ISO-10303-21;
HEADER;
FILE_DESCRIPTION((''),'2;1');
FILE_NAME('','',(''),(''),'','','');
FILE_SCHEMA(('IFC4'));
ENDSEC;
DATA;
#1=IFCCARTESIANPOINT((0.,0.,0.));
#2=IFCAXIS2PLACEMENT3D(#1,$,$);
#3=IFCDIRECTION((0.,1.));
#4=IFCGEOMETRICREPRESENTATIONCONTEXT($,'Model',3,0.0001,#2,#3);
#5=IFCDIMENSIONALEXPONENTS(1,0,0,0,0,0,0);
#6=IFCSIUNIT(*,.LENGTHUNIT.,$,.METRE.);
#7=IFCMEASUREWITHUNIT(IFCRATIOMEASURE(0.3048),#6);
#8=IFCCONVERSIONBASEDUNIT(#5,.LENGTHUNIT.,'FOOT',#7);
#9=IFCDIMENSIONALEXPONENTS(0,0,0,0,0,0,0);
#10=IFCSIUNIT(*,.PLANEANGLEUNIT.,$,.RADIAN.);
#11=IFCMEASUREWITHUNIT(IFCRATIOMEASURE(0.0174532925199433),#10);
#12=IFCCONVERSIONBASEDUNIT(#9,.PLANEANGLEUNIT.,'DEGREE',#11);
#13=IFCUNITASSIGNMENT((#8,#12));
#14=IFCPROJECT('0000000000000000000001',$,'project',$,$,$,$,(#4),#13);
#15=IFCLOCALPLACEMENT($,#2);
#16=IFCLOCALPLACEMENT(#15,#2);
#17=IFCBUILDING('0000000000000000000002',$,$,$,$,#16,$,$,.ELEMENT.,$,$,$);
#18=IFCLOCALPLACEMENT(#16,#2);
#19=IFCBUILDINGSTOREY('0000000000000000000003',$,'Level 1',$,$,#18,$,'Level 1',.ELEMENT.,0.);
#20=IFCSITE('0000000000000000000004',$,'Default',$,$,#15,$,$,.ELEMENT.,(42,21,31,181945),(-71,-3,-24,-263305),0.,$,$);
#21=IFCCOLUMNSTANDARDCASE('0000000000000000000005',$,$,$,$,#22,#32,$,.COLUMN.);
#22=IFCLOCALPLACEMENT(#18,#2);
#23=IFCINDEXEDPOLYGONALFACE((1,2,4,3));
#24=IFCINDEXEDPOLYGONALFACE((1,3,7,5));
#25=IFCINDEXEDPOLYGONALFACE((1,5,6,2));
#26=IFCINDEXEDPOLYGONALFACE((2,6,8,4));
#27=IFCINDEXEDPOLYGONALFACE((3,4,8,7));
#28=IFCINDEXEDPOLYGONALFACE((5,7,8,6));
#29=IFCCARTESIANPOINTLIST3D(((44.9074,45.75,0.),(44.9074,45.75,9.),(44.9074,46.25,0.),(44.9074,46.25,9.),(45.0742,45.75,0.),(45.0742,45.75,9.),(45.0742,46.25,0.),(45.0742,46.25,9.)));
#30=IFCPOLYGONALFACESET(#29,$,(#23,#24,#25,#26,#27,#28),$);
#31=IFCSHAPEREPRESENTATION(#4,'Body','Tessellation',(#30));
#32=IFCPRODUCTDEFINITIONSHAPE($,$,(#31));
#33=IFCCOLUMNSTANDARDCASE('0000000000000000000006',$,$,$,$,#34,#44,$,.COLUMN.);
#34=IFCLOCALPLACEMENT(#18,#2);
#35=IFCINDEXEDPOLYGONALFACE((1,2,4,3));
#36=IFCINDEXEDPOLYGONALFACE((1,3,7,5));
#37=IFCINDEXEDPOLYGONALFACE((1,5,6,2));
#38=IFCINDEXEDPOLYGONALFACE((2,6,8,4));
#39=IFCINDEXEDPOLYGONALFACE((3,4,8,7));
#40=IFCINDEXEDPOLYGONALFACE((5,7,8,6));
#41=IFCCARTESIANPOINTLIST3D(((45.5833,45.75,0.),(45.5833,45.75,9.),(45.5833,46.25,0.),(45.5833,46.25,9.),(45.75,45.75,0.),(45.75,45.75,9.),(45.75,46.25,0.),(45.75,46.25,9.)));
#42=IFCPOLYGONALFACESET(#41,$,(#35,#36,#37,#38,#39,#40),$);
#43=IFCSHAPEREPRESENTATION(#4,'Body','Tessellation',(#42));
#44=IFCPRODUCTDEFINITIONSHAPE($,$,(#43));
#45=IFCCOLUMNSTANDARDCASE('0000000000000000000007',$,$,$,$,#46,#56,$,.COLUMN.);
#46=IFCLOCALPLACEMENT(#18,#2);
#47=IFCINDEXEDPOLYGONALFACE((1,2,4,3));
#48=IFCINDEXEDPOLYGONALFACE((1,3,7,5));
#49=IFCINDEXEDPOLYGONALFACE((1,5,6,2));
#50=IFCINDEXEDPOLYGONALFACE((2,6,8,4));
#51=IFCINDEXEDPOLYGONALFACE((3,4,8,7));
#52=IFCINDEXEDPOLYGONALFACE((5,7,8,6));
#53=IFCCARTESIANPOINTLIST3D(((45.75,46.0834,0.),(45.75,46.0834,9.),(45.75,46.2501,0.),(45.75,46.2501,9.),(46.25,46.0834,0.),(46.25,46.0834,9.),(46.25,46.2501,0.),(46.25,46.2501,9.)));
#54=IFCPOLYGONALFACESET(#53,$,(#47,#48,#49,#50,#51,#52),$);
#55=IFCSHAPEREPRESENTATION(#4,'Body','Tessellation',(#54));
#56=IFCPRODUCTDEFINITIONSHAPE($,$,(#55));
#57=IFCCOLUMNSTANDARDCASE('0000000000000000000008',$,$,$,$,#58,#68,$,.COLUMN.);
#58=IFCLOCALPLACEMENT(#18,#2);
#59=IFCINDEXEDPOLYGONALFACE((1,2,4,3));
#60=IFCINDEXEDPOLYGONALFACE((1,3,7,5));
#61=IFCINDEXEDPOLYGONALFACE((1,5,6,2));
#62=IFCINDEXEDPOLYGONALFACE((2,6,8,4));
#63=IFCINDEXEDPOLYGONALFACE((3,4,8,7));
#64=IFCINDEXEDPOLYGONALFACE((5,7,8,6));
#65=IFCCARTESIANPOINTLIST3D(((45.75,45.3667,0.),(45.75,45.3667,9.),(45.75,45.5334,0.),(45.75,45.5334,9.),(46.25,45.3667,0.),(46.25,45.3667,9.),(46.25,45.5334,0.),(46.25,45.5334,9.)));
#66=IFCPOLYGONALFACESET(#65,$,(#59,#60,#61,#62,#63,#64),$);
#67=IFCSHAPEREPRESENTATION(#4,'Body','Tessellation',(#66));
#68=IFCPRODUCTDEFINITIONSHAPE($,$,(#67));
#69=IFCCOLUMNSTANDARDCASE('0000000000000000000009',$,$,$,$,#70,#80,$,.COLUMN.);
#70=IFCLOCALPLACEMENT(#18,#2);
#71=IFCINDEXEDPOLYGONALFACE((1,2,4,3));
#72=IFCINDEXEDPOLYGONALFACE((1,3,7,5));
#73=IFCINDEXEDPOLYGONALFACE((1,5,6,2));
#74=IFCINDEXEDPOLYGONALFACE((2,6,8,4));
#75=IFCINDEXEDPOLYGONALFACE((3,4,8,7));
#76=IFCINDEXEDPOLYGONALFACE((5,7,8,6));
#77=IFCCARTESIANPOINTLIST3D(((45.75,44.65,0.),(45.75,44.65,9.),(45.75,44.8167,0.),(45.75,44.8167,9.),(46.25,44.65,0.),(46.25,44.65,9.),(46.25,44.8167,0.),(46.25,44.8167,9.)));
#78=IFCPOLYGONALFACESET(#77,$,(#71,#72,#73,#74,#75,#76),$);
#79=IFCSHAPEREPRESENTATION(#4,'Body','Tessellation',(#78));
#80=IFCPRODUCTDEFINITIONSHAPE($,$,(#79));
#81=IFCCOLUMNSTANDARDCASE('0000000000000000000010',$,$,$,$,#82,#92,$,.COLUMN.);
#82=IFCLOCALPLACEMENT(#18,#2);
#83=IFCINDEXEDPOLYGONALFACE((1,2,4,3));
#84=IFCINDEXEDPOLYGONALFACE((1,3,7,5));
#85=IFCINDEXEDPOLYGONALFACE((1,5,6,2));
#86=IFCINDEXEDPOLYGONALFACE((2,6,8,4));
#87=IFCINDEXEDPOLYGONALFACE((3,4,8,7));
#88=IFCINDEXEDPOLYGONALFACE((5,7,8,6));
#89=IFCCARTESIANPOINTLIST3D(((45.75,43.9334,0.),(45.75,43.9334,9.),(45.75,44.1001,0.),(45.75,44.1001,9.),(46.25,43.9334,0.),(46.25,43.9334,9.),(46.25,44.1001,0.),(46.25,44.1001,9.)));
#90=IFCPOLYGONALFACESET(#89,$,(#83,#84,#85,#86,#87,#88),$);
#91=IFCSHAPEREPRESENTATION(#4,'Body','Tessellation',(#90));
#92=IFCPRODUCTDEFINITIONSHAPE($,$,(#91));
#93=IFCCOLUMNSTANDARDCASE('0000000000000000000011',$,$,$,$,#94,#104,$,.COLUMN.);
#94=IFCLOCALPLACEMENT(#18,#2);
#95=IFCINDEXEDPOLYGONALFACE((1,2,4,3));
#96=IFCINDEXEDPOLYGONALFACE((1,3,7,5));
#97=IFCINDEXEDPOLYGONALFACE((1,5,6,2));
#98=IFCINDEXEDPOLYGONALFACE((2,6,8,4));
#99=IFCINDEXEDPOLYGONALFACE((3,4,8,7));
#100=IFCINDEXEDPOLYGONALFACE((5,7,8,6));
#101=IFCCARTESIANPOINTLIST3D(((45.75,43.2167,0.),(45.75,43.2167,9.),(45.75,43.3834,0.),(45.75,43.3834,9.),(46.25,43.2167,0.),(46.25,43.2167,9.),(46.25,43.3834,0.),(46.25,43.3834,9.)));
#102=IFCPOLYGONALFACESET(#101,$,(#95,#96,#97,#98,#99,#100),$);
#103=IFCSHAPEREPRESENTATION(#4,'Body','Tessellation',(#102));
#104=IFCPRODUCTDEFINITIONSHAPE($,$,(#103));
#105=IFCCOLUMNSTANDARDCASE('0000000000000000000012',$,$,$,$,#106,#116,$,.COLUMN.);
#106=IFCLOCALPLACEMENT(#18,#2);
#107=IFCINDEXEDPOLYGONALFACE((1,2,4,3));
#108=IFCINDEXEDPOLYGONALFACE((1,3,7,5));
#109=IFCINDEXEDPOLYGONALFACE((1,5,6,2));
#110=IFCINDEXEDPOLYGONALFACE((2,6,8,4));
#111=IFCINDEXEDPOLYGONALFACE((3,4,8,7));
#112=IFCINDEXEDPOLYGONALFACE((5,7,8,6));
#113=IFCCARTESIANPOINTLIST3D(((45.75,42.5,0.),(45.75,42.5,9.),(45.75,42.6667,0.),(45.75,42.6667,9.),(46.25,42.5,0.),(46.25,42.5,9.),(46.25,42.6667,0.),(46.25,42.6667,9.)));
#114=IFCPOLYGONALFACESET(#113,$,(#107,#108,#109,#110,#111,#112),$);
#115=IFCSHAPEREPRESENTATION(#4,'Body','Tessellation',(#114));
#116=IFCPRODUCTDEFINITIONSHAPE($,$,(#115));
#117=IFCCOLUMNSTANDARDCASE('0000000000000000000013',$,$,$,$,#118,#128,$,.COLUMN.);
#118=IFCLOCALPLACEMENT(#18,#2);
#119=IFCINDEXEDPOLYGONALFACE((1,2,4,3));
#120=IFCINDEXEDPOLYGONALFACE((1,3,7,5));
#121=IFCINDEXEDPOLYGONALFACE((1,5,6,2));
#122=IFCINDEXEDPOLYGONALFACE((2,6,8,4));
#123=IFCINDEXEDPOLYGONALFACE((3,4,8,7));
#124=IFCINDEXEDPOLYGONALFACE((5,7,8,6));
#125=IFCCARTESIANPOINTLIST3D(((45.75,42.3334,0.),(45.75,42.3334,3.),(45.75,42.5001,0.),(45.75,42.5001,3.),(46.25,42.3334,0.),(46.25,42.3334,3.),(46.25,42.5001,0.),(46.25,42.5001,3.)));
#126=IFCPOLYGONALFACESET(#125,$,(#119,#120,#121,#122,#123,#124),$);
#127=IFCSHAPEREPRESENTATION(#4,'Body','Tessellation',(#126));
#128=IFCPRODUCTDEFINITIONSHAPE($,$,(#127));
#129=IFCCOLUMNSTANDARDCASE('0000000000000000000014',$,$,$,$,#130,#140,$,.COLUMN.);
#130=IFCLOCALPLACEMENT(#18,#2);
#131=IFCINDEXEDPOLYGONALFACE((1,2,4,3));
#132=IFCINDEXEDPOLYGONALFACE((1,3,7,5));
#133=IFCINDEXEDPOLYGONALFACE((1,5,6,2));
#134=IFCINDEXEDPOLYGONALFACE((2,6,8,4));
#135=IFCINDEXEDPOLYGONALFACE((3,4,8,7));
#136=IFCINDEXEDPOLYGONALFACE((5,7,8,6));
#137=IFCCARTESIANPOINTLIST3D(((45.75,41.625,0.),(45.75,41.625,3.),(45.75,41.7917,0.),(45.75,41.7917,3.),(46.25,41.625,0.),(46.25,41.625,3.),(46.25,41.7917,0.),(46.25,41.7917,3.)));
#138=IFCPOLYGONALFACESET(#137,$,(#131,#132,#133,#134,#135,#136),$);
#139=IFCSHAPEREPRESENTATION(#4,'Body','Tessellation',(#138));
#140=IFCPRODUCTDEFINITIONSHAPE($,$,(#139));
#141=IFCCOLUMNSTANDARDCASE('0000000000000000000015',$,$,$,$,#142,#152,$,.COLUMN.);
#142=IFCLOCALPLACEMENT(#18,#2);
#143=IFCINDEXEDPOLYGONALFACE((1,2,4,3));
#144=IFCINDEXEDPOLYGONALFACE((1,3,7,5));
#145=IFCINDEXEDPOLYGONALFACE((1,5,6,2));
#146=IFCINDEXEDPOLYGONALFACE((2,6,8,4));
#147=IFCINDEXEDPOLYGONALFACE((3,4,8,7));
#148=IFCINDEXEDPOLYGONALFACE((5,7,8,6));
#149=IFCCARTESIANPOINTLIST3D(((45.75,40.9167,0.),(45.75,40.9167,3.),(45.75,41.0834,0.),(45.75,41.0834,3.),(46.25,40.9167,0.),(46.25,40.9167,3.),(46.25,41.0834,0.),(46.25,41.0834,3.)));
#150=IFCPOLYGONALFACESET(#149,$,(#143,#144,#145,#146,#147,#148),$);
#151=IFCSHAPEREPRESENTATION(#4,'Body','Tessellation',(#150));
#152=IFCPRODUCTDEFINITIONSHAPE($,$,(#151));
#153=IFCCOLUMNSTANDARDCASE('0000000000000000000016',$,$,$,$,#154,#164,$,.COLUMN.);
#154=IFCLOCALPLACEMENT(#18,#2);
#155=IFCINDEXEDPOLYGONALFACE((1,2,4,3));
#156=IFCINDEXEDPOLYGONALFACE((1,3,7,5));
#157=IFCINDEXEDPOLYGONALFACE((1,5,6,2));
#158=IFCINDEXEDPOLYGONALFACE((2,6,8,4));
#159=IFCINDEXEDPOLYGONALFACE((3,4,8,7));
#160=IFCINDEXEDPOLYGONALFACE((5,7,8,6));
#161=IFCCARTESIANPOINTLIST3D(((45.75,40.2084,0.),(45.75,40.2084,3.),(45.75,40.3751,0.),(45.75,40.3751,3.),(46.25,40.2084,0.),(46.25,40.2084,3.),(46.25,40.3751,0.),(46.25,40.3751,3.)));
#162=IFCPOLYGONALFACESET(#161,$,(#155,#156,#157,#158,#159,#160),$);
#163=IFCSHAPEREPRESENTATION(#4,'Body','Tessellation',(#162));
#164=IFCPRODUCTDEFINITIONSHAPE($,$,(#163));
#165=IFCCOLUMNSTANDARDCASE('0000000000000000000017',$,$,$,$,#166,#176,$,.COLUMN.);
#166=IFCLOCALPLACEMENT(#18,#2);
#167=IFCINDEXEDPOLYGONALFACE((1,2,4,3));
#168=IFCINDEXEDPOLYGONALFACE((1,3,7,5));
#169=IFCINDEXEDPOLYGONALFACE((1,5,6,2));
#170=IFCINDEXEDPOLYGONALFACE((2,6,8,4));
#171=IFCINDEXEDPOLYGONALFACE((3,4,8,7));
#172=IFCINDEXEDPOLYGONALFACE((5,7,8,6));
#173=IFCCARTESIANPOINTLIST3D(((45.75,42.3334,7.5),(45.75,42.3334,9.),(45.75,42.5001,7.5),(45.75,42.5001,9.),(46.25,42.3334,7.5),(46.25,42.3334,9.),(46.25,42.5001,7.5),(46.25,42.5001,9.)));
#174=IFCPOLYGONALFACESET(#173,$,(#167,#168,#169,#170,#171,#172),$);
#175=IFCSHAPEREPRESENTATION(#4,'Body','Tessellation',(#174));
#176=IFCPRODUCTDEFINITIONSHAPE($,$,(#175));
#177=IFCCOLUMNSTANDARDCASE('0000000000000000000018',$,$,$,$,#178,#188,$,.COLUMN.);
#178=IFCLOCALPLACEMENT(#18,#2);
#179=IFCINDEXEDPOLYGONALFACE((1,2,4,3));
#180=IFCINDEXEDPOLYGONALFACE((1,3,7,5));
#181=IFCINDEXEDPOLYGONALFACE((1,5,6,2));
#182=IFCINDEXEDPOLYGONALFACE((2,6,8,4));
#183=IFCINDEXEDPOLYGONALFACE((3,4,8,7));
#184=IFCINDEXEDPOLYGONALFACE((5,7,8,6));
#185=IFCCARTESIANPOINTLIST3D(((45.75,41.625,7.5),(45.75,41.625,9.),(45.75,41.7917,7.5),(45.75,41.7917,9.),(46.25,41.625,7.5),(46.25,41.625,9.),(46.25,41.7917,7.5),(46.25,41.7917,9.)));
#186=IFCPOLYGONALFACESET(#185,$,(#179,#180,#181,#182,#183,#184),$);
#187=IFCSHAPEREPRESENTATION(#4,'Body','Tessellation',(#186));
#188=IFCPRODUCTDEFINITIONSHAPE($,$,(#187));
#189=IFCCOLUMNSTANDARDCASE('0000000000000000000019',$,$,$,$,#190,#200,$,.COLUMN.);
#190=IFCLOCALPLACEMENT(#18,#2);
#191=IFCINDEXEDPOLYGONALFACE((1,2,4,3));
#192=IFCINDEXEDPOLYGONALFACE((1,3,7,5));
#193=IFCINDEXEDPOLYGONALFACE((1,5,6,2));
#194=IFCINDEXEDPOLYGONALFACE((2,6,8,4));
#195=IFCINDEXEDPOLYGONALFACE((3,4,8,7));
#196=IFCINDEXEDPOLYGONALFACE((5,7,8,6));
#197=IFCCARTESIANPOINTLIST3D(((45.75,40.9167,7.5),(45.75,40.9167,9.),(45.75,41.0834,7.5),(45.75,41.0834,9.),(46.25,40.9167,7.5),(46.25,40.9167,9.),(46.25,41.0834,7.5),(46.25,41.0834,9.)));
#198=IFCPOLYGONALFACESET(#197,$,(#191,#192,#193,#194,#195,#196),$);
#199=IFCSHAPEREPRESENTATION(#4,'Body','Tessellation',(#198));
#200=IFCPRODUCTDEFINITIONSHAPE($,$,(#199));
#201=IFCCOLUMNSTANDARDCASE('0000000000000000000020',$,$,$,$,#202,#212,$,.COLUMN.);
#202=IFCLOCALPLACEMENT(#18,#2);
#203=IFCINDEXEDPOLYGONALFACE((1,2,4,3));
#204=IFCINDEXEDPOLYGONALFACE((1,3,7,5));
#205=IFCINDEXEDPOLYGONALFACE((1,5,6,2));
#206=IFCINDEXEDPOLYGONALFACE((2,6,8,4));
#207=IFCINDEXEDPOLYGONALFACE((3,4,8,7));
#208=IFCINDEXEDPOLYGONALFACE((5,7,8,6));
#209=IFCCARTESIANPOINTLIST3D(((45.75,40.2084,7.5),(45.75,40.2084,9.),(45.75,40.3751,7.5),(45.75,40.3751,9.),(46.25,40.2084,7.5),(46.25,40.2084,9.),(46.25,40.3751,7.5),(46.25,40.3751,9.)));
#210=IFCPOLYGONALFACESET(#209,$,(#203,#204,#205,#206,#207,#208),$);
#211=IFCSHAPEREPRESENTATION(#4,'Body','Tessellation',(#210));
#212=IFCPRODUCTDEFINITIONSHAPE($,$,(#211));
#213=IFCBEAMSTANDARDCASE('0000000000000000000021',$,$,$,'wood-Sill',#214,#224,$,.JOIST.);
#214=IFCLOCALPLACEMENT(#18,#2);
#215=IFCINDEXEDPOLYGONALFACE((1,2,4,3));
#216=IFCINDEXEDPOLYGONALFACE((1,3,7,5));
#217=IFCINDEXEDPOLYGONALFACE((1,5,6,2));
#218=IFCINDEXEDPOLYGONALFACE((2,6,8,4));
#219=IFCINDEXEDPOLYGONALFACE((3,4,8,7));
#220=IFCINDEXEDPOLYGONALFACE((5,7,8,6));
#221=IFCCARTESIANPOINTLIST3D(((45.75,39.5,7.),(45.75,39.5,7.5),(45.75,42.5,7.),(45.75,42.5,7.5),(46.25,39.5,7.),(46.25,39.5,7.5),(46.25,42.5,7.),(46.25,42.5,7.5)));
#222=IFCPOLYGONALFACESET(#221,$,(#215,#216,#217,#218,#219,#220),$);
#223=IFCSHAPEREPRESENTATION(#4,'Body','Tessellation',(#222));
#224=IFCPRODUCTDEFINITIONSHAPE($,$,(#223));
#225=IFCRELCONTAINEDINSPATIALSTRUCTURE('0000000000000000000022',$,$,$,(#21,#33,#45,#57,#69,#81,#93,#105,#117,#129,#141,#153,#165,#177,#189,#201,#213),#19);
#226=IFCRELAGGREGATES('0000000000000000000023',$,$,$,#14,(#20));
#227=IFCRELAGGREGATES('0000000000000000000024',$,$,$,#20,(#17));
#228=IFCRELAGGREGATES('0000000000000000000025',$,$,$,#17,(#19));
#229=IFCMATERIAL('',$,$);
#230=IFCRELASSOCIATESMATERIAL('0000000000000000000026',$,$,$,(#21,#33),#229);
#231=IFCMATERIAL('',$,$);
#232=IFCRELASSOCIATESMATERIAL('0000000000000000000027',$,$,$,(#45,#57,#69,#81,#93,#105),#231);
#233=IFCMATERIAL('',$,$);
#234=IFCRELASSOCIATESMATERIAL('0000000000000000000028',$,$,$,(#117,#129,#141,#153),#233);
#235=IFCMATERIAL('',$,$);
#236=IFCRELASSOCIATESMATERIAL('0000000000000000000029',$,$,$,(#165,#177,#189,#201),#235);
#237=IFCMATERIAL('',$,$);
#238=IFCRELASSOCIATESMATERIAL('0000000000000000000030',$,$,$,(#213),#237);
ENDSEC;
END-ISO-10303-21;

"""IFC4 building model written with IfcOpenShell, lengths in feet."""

from ifc_helpers import new_model, entity, si_unit, converted_unit, direction, frame, origin, place, context, project, spatial, rectangle, extrude, material, element, save


model = new_model("IFC4")

# Units and contexts
model_context = context("Model", 3, precision=0.0001, world=origin(), true_north=direction((0.0, 1.0)))
ifc_project = project(units=[converted_unit("LENGTHUNIT", "FOOT", entity("IfcRatioMeasure", 0.3048), si_unit("LENGTHUNIT", "METRE"), dimensions=[1, 0, 0, 0, 0, 0, 0]), converted_unit("PLANEANGLEUNIT", "DEGREE", entity("IfcRatioMeasure", 0.0174532925199433), si_unit("PLANEANGLEUNIT", "RADIAN"), dimensions=[0, 0, 0, 0, 0, 0, 0])], contexts=[model_context])

# Site, building, storey
site_placement = place(None, origin())
site = spatial("IfcSite", under=ifc_project, at=site_placement, Name="Default", CompositionType="ELEMENT", RefLatitude=(42, 21, 31, 181945), RefLongitude=(-71, -3, -24, -263305), RefElevation=0.0)
building_placement = place(site_placement, origin())
building = spatial("IfcBuilding", under=site, at=building_placement, CompositionType="ELEMENT")
storey_placement = place(building_placement, origin())
storey = spatial("IfcBuildingStorey", under=building, at=storey_placement, Name="Level 1", LongName="Level 1", CompositionType="ELEMENT", Elevation=0.0)

# Columns
ifc_material_1 = material(Name="")
placement_1 = place(storey_placement, frame((-0.25, 46.0, 0.0)))
for number, where, z_axis, x_axis in (
    (1, (45.2408, 0.0, 0.0), (0.0, 0.0, 1.0), (1.0, 0.0, 0.0)),
    (2, (45.9167, 0.0, 0.0), (0.0, 0.0, 1.0), (1.0, 0.0, 0.0)),
):
    element("IfcColumnStandardCase", number, at=place(placement_1, frame(where, z_axis=z_axis, x_axis=x_axis)), inside=storey, material=ifc_material_1, PredefinedType="COLUMN", context=model_context, shape_type="SweptSolid", body=[
        extrude(rectangle(XDim=0.1667, YDim=0.5), origin(), (0.0, 0.0, 1.0), 9.0),
    ])
ifc_material_2 = material(Name="")
placement_2 = place(storey_placement, frame((46.0, 46.25, 0.0), z_axis=(0.0, 0.0, 1.0), x_axis=(0.0, -1.0, 0.0)))
for number, where, z_axis, x_axis in (
    (3, (0.0833, 0.0, 0.0), (0.0, 0.0, 1.0), (1.0, 0.0, 0.0)),
    (4, (0.8, 0.0, 0.0), (0.0, 0.0, 1.0), (1.0, 0.0, 0.0)),
    (5, (1.5167, 0.0, 0.0), (0.0, 0.0, 1.0), (1.0, 0.0, 0.0)),
    (6, (2.2333, 0.0, 0.0), (0.0, 0.0, 1.0), (1.0, 0.0, 0.0)),
    (7, (2.95, 0.0, 0.0), (0.0, 0.0, 1.0), (1.0, 0.0, 0.0)),
    (8, (3.6667, 0.0, 0.0), (0.0, 0.0, 1.0), (1.0, 0.0, 0.0)),
):
    element("IfcColumnStandardCase", number, at=place(placement_2, frame(where, z_axis=z_axis, x_axis=x_axis)), inside=storey, material=ifc_material_2, PredefinedType="COLUMN", context=model_context, shape_type="SweptSolid", body=[
        extrude(rectangle(XDim=0.1667, YDim=0.5), origin(), (0.0, 0.0, 1.0), 9.0),
    ])
ifc_material_3 = material(Name="")
for number, where, z_axis, x_axis in (
    (9, (3.8333, 0.0, 0.0), (0.0, 0.0, 1.0), (1.0, 0.0, 0.0)),
    (10, (4.5417, 0.0, 0.0), (0.0, 0.0, 1.0), (1.0, 0.0, 0.0)),
    (11, (5.25, 0.0, 0.0), (0.0, 0.0, 1.0), (1.0, 0.0, 0.0)),
    (12, (5.9583, 0.0, 0.0), (0.0, 0.0, 1.0), (1.0, 0.0, 0.0)),
):
    element("IfcColumnStandardCase", number, at=place(placement_2, frame(where, z_axis=z_axis, x_axis=x_axis)), inside=storey, material=ifc_material_3, PredefinedType="COLUMN", context=model_context, shape_type="SweptSolid", body=[
        extrude(rectangle(XDim=0.1667, YDim=0.5), origin(), (0.0, 0.0, 1.0), 3.0),
    ])
ifc_material_4 = material(Name="")
for number, where, z_axis, x_axis in (
    (13, (3.8333, 0.0, 7.5), (0.0, 0.0, 1.0), (1.0, 0.0, 0.0)),
    (14, (4.5417, 0.0, 7.5), (0.0, 0.0, 1.0), (1.0, 0.0, 0.0)),
    (15, (5.25, 0.0, 7.5), (0.0, 0.0, 1.0), (1.0, 0.0, 0.0)),
    (16, (5.9583, 0.0, 7.5), (0.0, 0.0, 1.0), (1.0, 0.0, 0.0)),
):
    element("IfcColumnStandardCase", number, at=place(placement_2, frame(where, z_axis=z_axis, x_axis=x_axis)), inside=storey, material=ifc_material_4, PredefinedType="COLUMN", context=model_context, shape_type="SweptSolid", body=[
        extrude(rectangle(XDim=0.1667, YDim=0.5), origin(), (0.0, 0.0, 1.0), 1.5),
    ])

# Beam
ifc_material_5 = material(Name="")
for number, where, z_axis, x_axis in (
    (17, (5.25, 0.0, 7.0), (0.0, 0.0, 1.0), (-1.0, 0.0, 0.0)),
):
    element("IfcBeamStandardCase", number, at=place(placement_2, frame(where, z_axis=z_axis, x_axis=x_axis)), inside=storey, material=ifc_material_5, ObjectType="wood-Sill", PredefinedType="JOIST", context=model_context, shape_type="SweptSolid", body=[
        extrude(rectangle(XDim=3.0, YDim=0.5), origin(), (0.0, 0.0, 1.0), 0.5),
    ])

save(model, "model.ifc")
